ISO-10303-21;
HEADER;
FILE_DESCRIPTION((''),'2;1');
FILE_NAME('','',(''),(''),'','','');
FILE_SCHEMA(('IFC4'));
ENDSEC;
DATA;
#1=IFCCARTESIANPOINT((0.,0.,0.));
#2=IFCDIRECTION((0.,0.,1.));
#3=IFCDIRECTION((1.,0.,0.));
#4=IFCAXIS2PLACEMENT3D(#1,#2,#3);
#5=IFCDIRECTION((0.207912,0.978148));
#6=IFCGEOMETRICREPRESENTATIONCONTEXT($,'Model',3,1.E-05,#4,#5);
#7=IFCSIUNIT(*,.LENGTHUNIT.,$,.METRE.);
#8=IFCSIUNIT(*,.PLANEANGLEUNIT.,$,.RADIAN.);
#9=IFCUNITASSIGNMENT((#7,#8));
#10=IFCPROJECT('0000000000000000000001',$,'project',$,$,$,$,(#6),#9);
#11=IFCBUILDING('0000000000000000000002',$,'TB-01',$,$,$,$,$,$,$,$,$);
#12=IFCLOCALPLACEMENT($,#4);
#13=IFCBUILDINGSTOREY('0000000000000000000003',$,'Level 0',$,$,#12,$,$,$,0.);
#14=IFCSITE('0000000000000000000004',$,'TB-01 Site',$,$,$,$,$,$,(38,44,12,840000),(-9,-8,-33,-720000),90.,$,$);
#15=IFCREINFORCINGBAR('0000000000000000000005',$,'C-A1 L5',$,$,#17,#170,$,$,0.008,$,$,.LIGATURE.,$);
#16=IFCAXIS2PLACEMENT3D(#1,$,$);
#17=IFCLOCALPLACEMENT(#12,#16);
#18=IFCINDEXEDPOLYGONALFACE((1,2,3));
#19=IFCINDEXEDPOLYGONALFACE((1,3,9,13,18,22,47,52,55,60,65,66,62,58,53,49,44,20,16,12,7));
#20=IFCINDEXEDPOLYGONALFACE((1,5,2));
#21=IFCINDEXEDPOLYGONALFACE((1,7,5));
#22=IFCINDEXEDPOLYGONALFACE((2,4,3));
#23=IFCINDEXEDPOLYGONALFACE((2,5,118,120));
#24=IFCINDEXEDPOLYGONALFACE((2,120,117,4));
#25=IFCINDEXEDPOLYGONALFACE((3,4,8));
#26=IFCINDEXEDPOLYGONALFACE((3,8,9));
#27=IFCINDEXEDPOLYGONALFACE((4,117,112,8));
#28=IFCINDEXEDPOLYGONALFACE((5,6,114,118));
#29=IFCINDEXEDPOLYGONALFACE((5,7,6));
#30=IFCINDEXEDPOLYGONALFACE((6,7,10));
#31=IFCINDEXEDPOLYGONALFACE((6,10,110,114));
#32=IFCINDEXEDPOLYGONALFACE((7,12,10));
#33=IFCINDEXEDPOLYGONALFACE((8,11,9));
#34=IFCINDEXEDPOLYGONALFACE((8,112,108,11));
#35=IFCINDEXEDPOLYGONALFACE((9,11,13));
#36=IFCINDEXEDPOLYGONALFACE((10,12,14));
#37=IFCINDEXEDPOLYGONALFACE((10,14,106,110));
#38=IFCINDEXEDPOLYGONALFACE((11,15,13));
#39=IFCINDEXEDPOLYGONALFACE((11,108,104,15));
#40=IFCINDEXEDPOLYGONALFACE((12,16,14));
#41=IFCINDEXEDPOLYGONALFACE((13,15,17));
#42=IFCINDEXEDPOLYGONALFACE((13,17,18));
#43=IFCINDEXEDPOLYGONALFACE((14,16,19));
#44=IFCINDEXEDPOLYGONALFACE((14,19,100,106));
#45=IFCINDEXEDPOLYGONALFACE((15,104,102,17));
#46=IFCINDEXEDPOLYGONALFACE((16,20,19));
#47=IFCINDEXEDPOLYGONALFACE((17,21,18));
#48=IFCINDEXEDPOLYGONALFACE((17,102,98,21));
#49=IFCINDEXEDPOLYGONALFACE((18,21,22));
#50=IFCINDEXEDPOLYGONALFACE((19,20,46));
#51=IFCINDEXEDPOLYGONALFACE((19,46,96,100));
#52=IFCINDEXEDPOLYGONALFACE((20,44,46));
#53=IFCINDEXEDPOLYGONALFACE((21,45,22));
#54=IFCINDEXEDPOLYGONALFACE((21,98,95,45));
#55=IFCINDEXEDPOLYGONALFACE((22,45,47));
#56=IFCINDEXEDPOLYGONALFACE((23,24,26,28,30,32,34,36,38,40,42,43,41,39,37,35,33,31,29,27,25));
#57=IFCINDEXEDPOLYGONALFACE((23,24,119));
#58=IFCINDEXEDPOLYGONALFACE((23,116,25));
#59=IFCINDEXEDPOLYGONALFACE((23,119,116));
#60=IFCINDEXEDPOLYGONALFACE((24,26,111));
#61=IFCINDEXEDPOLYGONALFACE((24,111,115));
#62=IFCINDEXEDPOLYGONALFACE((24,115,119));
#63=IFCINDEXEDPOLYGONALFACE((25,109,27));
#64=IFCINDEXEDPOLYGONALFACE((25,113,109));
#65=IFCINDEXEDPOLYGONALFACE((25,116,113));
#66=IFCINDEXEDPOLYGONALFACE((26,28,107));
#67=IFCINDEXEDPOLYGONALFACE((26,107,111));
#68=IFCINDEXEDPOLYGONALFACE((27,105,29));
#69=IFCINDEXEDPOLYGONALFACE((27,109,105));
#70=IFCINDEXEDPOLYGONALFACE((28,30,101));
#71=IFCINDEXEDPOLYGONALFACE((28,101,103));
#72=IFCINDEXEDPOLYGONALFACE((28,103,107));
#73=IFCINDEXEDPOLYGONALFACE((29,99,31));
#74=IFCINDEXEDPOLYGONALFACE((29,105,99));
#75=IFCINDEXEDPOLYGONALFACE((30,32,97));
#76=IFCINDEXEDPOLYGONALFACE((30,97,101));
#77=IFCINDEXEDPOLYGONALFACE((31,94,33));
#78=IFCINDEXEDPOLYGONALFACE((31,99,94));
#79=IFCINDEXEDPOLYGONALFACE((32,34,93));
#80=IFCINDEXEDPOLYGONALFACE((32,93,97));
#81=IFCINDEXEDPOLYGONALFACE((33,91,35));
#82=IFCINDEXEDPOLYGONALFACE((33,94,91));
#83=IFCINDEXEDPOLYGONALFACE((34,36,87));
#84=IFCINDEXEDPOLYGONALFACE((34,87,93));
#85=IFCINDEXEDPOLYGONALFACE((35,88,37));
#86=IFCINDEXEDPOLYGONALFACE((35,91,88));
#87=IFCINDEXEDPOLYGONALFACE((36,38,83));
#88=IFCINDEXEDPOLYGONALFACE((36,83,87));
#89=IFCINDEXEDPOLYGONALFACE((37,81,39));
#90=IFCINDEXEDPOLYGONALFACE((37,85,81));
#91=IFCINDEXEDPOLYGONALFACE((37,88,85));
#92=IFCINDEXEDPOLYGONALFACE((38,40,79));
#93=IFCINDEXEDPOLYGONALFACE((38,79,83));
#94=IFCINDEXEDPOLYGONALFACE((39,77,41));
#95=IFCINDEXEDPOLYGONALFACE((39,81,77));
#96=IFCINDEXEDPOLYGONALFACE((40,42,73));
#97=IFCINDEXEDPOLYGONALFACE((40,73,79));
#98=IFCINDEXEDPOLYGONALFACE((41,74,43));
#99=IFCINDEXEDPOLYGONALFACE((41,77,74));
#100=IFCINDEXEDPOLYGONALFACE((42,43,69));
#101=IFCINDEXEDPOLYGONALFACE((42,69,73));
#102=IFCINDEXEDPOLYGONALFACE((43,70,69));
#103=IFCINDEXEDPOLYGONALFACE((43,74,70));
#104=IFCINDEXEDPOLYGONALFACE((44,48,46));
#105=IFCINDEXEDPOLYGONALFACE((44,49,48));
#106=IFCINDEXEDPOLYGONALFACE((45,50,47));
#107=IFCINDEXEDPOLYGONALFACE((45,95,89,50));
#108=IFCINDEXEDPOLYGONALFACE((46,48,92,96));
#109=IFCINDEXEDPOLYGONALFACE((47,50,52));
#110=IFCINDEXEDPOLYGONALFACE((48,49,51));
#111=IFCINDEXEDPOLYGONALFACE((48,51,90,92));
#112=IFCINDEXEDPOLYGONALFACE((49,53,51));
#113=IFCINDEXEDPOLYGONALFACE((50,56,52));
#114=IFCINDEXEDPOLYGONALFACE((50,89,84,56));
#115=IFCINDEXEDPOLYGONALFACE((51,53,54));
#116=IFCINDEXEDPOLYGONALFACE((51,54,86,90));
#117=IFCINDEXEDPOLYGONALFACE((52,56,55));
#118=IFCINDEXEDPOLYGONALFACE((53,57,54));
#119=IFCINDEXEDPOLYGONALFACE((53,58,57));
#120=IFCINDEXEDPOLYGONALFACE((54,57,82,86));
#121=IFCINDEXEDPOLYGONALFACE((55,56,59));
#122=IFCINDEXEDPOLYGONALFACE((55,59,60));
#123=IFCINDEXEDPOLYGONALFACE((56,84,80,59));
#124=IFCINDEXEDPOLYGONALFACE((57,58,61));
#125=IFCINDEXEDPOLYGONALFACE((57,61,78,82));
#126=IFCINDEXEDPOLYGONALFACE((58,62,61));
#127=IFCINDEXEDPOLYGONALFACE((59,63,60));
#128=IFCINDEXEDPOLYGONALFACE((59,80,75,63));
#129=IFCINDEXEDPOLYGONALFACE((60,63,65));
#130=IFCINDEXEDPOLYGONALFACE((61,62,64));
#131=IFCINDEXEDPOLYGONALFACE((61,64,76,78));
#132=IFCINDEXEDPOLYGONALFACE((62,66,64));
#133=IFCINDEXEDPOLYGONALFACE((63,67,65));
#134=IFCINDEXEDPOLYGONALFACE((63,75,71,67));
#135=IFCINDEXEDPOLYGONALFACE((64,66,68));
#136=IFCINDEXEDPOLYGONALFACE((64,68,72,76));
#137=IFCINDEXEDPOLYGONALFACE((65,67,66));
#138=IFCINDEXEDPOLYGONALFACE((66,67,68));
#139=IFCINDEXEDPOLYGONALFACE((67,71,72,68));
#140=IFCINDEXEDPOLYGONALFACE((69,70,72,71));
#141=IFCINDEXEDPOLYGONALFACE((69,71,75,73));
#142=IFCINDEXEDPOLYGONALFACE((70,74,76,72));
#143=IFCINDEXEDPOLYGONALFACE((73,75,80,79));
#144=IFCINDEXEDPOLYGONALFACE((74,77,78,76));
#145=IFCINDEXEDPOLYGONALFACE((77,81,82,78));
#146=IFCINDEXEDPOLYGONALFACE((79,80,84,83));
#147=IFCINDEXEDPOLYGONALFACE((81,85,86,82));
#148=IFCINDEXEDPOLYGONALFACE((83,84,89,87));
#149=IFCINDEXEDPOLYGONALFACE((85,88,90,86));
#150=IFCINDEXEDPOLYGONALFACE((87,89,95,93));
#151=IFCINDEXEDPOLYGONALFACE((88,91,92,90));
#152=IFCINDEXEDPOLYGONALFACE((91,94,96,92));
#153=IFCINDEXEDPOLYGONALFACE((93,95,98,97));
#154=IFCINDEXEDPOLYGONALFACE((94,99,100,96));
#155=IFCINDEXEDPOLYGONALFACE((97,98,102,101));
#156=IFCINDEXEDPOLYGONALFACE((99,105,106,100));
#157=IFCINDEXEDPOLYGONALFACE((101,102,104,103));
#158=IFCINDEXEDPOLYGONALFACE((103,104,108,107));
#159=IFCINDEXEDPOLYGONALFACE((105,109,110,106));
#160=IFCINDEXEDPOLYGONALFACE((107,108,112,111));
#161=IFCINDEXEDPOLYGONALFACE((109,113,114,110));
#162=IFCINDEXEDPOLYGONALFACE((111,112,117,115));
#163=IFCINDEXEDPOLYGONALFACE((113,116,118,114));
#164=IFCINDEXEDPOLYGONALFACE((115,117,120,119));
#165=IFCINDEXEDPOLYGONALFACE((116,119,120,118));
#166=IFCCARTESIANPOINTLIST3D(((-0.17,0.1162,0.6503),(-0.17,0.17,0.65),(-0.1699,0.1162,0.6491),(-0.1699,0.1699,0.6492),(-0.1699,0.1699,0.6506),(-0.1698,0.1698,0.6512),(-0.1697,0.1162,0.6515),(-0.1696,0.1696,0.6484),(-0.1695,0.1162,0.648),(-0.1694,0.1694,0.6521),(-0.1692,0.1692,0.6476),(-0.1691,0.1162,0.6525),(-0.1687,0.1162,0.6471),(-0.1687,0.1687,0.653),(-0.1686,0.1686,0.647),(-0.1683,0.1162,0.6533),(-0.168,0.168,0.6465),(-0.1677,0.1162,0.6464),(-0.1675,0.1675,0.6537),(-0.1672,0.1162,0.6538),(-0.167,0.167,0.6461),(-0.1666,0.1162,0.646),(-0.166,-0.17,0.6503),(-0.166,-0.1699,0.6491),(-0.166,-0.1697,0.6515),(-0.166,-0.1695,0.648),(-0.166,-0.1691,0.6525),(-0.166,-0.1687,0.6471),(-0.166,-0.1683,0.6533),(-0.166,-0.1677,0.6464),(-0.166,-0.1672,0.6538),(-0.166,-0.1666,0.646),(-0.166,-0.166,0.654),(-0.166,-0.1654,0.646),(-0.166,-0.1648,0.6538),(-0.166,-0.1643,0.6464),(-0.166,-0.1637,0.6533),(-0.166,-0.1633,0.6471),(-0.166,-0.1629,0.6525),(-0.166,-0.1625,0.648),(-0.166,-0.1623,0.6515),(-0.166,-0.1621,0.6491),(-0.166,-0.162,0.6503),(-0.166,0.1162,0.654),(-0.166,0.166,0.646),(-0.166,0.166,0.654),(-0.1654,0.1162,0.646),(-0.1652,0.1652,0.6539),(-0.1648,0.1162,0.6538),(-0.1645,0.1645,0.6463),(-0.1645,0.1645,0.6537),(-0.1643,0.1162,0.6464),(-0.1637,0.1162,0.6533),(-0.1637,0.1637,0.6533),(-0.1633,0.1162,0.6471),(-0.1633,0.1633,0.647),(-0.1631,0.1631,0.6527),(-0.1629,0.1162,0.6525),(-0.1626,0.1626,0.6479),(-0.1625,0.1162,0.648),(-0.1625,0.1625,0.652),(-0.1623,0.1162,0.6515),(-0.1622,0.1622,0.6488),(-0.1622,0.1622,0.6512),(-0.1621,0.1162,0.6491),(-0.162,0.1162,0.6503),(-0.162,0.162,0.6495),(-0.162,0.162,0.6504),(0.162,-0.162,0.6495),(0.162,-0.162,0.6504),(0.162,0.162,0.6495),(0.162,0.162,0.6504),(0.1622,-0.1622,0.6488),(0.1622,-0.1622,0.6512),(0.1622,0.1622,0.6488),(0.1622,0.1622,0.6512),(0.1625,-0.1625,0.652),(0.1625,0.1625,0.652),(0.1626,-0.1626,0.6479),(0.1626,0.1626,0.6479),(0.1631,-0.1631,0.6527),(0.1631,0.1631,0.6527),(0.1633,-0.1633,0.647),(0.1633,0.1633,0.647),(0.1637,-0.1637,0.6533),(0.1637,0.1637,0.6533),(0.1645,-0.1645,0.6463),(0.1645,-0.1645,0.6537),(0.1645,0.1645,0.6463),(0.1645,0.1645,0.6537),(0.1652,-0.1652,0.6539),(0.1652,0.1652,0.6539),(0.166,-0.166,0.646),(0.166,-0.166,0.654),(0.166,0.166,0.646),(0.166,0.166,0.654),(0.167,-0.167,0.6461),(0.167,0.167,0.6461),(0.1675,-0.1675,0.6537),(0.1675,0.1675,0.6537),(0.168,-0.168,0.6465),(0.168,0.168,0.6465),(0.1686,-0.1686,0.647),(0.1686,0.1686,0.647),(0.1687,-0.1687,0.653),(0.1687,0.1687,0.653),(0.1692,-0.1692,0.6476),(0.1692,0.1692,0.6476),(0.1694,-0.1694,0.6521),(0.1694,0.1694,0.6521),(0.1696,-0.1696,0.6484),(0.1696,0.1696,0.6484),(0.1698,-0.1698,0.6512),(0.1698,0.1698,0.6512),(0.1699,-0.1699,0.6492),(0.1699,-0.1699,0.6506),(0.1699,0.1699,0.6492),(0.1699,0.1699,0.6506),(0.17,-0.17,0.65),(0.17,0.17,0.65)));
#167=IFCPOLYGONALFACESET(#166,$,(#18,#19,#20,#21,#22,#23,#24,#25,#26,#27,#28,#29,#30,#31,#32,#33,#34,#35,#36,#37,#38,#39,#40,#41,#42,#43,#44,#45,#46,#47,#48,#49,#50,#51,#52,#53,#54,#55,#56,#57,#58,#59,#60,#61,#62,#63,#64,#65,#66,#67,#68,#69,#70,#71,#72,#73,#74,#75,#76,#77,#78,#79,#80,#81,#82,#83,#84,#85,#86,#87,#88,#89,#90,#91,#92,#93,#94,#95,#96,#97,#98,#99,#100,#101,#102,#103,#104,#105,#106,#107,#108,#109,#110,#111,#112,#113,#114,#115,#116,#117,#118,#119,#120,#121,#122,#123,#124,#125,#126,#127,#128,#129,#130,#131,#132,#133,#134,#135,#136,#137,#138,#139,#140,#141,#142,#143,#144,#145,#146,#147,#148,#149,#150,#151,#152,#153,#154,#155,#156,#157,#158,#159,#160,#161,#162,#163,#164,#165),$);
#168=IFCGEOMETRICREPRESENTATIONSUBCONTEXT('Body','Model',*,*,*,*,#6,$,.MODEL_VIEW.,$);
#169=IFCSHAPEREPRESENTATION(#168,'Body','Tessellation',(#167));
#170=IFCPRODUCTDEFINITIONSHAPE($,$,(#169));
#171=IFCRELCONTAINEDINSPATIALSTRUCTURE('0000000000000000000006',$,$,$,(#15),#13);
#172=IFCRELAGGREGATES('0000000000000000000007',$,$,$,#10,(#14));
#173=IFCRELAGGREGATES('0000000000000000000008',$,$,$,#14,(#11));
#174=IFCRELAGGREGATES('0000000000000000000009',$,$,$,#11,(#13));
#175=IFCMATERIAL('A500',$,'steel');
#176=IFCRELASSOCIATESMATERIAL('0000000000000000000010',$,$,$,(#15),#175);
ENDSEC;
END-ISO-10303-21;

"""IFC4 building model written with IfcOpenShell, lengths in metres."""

from ifc_helpers import new_model, entity, si_unit, direction, origin_with_axes, place, context, subcontext, project, spatial, material, element, save


model = new_model("IFC4")

# Units and contexts
model_context = context("Model", 3, precision=1e-05, world=origin_with_axes(), true_north=direction((0.207912, 0.978148)))
body_context = subcontext(model_context, "Body", "Model", "MODEL_VIEW")
ifc_project = project(units=[si_unit("LENGTHUNIT", "METRE"), si_unit("PLANEANGLEUNIT", "RADIAN")], contexts=[model_context])

# Site, building, storey
site = spatial("IfcSite", under=ifc_project, Name="TB-01 Site", RefLatitude=(38, 44, 12, 840000), RefLongitude=(-9, -8, -33, -720000), RefElevation=90.0)
building = spatial("IfcBuilding", under=site, Name="TB-01")
storey_placement = place(None, origin_with_axes())
storey = spatial("IfcBuildingStorey", under=building, at=storey_placement, Name="Level 0", Elevation=0.0)

# Reinforcing bar
ifc_material_1 = material(Name="A500", Category="steel")
reinforcing_bar_1_placement = place(storey_placement, origin_with_axes())
element("IfcReinforcingBar", 1, at=reinforcing_bar_1_placement, inside=storey, material=ifc_material_1, Name="C-A1 L5", NominalDiameter=0.008, PredefinedType="LIGATURE", context=body_context, shape_type="AdvancedSweptSolid", body=[
    entity("IfcSweptDiskSolid", entity("IfcPolyline", [entity("IfcCartesianPoint", [-0.166, -0.166, 0.65]), entity("IfcCartesianPoint", [0.166, -0.166, 0.65]), entity("IfcCartesianPoint", [0.166, 0.166, 0.65]), entity("IfcCartesianPoint", [-0.166, 0.166, 0.65]), entity("IfcCartesianPoint", [-0.166, 0.1162, 0.65])]), 0.004),
])

save(model, "model.ifc")
